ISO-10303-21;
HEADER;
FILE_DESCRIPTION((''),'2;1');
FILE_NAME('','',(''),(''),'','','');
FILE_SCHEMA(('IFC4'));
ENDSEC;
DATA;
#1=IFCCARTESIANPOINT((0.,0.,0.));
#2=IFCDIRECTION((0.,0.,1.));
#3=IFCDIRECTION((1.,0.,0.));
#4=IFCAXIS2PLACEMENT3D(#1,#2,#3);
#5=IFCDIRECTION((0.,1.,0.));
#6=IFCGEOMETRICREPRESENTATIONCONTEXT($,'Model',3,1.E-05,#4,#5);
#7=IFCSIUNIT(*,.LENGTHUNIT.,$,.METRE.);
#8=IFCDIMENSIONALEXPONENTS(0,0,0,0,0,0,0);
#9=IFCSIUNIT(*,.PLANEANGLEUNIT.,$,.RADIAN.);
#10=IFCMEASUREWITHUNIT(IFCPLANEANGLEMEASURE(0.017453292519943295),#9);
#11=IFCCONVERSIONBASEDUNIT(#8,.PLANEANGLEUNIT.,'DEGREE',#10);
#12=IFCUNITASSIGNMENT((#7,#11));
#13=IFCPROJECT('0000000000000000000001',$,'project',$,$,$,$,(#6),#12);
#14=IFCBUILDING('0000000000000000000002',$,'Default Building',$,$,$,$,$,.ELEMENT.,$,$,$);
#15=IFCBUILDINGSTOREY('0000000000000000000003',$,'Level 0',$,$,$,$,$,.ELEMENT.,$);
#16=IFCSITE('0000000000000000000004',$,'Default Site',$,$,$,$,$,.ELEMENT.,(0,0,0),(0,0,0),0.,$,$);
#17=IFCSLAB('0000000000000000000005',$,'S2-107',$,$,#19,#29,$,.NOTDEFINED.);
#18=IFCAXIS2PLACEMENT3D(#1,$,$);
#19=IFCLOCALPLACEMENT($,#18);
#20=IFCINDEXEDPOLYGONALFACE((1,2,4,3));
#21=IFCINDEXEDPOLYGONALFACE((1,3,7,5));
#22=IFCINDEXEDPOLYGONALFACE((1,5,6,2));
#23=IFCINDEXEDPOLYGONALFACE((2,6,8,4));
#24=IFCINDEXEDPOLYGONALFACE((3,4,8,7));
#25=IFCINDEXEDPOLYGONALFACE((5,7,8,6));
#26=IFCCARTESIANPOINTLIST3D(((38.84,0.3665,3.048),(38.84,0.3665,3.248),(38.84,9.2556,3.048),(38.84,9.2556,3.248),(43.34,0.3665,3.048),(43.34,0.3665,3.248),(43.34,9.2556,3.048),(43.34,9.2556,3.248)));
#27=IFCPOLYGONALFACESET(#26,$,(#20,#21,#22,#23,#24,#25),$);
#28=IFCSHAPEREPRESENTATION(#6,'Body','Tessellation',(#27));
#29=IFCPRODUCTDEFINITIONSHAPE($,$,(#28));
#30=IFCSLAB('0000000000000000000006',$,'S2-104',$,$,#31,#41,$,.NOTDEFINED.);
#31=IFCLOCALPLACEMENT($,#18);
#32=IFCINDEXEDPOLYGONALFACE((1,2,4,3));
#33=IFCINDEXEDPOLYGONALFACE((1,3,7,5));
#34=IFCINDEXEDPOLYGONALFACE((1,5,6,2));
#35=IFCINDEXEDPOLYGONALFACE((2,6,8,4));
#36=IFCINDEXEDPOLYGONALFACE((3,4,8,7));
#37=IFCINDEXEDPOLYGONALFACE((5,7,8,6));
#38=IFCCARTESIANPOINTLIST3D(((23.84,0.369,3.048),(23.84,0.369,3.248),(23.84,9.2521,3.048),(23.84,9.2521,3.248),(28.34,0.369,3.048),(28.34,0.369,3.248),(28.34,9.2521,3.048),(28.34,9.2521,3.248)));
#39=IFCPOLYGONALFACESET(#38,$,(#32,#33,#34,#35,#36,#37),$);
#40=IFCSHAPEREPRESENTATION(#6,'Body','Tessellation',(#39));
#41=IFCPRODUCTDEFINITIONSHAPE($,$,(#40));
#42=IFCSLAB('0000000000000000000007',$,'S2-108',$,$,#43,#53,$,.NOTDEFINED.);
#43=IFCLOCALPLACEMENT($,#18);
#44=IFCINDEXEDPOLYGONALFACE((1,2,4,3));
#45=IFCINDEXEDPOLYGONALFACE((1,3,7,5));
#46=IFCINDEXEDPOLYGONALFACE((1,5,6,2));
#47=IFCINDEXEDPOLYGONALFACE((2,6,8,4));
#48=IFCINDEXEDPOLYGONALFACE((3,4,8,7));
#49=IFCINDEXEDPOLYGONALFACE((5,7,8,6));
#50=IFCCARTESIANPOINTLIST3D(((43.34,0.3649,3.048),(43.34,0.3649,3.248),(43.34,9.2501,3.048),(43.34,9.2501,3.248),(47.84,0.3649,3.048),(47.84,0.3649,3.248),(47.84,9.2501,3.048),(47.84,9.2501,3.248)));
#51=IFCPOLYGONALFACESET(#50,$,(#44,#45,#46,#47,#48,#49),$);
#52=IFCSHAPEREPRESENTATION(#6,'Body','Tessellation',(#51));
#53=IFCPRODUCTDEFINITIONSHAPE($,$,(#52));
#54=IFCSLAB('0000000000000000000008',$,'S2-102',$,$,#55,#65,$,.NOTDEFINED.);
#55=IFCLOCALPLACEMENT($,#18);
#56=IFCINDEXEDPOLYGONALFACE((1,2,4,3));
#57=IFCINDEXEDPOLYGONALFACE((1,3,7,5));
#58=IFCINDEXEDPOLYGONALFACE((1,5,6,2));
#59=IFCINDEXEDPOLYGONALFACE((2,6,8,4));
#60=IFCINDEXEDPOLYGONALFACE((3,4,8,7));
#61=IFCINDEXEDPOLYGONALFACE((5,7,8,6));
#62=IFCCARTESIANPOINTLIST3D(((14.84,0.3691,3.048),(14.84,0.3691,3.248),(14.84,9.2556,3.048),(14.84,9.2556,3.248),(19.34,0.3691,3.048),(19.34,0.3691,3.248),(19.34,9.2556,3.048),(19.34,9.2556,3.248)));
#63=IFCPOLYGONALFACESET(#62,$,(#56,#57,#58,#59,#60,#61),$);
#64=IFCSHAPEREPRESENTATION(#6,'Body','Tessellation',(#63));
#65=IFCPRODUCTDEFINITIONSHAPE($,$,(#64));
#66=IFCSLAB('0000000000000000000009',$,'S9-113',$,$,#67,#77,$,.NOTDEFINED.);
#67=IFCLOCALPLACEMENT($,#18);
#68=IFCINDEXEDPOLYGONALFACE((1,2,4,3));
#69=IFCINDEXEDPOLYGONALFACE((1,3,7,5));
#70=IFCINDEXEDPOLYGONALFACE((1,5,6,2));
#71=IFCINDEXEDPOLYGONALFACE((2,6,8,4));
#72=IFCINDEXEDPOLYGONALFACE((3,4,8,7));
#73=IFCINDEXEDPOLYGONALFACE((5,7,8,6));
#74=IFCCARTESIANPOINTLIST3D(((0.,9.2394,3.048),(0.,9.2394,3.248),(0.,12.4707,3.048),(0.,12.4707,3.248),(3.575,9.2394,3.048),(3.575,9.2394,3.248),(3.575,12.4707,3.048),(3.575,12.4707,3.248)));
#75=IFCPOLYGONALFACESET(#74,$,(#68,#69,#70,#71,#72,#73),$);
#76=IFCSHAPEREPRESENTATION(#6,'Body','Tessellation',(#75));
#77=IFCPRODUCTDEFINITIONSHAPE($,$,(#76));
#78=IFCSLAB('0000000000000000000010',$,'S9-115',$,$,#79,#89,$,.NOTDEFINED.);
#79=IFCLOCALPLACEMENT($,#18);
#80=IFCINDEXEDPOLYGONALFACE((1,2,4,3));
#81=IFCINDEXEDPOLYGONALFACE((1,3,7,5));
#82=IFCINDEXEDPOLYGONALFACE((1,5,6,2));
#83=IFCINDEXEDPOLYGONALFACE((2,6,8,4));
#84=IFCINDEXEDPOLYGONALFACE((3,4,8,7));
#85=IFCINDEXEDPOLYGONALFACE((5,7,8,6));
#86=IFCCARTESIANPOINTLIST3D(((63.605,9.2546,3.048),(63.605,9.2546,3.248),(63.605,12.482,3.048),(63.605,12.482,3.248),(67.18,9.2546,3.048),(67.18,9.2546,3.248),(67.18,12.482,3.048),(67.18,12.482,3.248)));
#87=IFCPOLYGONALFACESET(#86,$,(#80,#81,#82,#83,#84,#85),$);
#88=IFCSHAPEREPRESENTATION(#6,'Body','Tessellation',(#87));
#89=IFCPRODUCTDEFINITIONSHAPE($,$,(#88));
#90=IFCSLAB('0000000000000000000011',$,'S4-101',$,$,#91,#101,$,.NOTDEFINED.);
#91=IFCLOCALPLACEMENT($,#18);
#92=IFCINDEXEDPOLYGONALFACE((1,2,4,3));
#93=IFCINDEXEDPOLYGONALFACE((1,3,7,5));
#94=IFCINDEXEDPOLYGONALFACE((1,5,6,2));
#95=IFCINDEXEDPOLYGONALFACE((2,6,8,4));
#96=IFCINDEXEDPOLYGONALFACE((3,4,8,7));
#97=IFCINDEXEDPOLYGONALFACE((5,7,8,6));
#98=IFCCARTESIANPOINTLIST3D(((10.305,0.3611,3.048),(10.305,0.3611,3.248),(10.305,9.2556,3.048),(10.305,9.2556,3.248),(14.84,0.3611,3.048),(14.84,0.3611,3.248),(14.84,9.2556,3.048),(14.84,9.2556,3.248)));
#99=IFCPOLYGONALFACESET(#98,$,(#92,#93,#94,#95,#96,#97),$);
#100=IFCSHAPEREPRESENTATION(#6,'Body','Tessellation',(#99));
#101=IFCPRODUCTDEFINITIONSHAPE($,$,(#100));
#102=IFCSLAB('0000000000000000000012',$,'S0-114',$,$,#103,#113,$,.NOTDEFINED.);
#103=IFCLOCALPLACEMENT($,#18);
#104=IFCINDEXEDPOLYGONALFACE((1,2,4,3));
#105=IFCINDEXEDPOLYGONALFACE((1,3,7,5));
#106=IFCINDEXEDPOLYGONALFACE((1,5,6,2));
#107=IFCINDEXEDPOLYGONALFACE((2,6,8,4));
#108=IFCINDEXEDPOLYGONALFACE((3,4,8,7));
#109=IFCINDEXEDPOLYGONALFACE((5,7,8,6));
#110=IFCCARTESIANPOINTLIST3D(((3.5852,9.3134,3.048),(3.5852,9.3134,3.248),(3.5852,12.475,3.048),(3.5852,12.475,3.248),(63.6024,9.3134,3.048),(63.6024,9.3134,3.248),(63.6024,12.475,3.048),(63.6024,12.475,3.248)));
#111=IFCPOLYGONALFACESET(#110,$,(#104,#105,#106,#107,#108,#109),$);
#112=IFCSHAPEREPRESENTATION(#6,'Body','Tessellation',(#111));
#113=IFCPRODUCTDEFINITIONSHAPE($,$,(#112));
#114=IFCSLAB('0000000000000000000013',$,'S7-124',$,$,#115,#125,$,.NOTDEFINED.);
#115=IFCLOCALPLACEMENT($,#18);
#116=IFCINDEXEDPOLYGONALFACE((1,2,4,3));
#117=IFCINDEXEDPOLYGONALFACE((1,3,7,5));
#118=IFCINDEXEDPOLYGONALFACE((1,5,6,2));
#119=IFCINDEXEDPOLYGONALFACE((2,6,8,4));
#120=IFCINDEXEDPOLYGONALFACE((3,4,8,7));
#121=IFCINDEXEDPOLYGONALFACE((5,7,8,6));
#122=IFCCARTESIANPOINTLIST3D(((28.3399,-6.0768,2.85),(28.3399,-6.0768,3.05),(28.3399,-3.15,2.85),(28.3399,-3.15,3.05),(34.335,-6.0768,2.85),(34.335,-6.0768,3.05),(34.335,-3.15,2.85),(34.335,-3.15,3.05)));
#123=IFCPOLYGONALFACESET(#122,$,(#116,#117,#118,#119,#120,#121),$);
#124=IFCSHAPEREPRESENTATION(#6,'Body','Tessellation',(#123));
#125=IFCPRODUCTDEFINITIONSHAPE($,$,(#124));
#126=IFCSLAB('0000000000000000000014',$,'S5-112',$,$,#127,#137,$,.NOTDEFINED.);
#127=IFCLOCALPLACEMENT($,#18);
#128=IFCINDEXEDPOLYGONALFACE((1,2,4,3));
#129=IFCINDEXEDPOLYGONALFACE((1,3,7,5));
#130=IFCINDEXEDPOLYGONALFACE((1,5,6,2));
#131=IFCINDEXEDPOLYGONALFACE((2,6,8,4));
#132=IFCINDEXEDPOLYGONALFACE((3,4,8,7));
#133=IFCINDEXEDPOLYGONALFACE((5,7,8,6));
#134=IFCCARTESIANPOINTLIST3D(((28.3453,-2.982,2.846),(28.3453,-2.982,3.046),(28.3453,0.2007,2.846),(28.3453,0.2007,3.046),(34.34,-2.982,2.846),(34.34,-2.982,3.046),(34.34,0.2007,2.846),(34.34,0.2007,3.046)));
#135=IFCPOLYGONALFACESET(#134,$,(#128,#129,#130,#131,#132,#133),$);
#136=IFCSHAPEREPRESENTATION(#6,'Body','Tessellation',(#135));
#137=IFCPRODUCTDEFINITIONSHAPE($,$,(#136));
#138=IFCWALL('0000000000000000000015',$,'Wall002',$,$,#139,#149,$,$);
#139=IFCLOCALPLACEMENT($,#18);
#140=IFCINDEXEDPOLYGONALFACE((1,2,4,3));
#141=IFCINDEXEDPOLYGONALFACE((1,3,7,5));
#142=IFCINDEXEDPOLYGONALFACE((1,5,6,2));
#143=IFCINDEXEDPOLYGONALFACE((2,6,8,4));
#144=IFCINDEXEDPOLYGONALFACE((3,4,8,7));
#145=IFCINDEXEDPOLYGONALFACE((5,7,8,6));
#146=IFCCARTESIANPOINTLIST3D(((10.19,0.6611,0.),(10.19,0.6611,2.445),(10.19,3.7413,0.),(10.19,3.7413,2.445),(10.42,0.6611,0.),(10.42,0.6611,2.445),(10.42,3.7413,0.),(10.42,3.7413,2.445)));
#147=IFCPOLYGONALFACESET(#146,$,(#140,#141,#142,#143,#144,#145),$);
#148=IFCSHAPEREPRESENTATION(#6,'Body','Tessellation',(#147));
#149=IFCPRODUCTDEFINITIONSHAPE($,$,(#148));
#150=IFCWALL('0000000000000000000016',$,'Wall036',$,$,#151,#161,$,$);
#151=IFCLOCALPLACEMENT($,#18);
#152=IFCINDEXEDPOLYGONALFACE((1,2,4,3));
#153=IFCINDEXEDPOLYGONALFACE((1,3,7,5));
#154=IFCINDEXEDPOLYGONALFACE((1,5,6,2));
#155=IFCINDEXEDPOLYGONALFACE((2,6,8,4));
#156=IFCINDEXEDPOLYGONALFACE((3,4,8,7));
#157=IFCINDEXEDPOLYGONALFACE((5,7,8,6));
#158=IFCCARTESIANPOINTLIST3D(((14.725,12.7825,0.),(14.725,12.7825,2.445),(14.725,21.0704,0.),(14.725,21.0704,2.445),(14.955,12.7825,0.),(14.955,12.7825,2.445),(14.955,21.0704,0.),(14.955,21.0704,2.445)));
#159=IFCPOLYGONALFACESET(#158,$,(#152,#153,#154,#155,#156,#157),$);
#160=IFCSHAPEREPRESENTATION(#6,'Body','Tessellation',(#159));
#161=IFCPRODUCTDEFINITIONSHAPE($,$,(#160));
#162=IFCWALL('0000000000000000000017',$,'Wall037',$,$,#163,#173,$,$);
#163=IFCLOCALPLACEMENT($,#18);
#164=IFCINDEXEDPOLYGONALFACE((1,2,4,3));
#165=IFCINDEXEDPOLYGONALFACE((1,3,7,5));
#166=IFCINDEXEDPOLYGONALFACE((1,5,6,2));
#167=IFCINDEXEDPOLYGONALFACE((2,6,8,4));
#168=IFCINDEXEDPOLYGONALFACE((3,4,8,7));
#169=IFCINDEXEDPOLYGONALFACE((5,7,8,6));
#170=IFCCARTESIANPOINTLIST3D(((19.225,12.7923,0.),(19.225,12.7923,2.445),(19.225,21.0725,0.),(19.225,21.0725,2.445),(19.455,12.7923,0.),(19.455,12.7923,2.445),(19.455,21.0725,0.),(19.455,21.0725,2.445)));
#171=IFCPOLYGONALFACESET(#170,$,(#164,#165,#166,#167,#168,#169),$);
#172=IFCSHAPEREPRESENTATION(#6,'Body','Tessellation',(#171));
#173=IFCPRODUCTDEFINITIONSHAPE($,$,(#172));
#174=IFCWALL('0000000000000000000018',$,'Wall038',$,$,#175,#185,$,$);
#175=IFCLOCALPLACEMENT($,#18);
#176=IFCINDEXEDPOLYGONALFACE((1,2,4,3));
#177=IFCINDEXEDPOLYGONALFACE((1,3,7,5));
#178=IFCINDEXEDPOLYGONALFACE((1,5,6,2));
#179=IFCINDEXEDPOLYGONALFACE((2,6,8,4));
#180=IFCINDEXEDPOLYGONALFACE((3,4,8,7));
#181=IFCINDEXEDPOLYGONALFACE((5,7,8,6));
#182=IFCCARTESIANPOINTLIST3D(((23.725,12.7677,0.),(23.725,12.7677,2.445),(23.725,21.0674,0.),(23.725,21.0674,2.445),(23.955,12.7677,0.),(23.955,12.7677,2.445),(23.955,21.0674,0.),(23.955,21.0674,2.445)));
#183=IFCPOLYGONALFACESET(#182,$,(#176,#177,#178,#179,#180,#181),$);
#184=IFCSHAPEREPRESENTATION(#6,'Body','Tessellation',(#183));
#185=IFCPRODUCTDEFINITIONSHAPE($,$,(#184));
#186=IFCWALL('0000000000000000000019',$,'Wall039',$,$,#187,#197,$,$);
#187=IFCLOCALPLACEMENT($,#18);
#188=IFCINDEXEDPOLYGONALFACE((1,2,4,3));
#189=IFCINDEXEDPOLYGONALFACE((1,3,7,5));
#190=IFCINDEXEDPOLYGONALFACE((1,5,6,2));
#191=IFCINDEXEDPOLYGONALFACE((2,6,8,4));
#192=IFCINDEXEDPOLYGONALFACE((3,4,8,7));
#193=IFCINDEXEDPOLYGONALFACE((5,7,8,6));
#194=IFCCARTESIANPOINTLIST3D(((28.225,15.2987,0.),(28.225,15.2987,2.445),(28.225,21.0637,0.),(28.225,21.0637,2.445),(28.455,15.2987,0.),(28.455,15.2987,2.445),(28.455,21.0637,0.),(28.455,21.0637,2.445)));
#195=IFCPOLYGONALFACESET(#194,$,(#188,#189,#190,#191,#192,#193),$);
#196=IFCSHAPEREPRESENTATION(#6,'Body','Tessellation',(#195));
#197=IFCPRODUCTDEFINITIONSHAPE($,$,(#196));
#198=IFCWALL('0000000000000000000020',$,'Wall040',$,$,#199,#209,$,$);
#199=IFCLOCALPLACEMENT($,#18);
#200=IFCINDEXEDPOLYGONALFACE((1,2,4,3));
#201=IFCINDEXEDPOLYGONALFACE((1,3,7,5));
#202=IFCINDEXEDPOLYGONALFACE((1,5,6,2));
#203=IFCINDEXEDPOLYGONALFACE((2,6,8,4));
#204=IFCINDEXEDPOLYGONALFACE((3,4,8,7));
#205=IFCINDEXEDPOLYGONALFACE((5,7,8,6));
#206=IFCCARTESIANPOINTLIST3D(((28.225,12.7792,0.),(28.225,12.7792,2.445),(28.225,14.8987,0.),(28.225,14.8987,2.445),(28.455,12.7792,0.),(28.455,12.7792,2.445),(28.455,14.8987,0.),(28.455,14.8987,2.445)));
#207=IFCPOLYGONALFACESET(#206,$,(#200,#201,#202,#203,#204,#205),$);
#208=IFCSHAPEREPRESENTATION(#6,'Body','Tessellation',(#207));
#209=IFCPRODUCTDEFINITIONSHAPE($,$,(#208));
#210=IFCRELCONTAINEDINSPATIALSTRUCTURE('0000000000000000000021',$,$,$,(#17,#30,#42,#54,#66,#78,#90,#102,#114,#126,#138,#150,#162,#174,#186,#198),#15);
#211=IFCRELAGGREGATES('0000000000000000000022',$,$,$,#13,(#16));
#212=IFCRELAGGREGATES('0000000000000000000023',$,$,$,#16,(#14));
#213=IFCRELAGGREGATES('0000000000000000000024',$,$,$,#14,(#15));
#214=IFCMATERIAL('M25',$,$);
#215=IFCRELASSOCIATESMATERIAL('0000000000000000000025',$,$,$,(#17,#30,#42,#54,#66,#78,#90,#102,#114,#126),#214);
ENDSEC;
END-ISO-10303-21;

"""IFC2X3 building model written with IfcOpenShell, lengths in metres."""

from ifc_helpers import new_model, entity, si_unit, converted_unit, direction, frame, frame_2d, origin_with_axes, place, context, project, spatial, rectangle, extrude, material, element, save


model = new_model("IFC2X3")

# Units and contexts
model_context = context("Model", 3, precision=1e-05, world=origin_with_axes(), true_north=direction((0.0, 1.0, 0.0)))
ifc_project = project(units=[si_unit("LENGTHUNIT", "METRE"), converted_unit("PLANEANGLEUNIT", "DEGREE", entity("IfcPlaneAngleMeasure", 0.017453292519943295), si_unit("PLANEANGLEUNIT", "RADIAN"), dimensions=[0, 0, 0, 0, 0, 0, 0])], contexts=[model_context])

# Site, building, storey
site = spatial("IfcSite", under=ifc_project, Name="Default Site", CompositionType="ELEMENT", RefLatitude=(0, 0, 0), RefLongitude=(0, 0, 0), RefElevation=0.0)
building = spatial("IfcBuilding", under=site, Name="Default Building", CompositionType="ELEMENT")
storey = spatial("IfcBuildingStorey", under=building, Name="Level 0", CompositionType="ELEMENT")

# Slabs
ifc_material = material(Name="M25")
placement = place(None, origin_with_axes())
element("IfcSlab", 1, at=placement, inside=storey, material=ifc_material, Name="S2-107", PredefinedType="NOTDEFINED", context=model_context, shape_type="SweptSolid", body=[
    extrude(rectangle(XDim=4.5, YDim=8.8891, at=frame_2d((0.0, 0.0), x_axis=(1.0, 0.0, 0.0))), frame((41.09, 4.811, 3.048), z_axis=(0.0, 0.0, 1.0), x_axis=(1.0, 0.0, 0.0)), (0.0, 0.0, 1.0), 0.2),
])
element("IfcSlab", 2, at=placement, inside=storey, material=ifc_material, Name="S2-104", PredefinedType="NOTDEFINED", context=model_context, shape_type="SweptSolid", body=[
    extrude(rectangle(XDim=4.5, YDim=8.8831, at=frame_2d((0.0, 0.0), x_axis=(1.0, 0.0, 0.0))), frame((26.09, 4.8106, 3.048), z_axis=(0.0, 0.0, 1.0), x_axis=(1.0, 0.0, 0.0)), (0.0, 0.0, 1.0), 0.2),
])
element("IfcSlab", 3, at=placement, inside=storey, material=ifc_material, Name="S2-108", PredefinedType="NOTDEFINED", context=model_context, shape_type="SweptSolid", body=[
    extrude(rectangle(XDim=4.5, YDim=8.8852, at=frame_2d((0.0, 0.0), x_axis=(1.0, 0.0, 0.0))), frame((45.59, 4.8075, 3.048), z_axis=(0.0, 0.0, 1.0), x_axis=(1.0, 0.0, 0.0)), (0.0, 0.0, 1.0), 0.2),
])
element("IfcSlab", 4, at=placement, inside=storey, material=ifc_material, Name="S2-102", PredefinedType="NOTDEFINED", context=model_context, shape_type="SweptSolid", body=[
    extrude(rectangle(XDim=4.5, YDim=8.8865, at=frame_2d((0.0, 0.0), x_axis=(1.0, 0.0, 0.0))), frame((17.09, 4.8123, 3.048), z_axis=(0.0, 0.0, 1.0), x_axis=(1.0, 0.0, 0.0)), (0.0, 0.0, 1.0), 0.2),
])
element("IfcSlab", 5, at=placement, inside=storey, material=ifc_material, Name="S9-113", PredefinedType="NOTDEFINED", context=model_context, shape_type="SweptSolid", body=[
    extrude(rectangle(XDim=3.575, YDim=3.2313, at=frame_2d((0.0, 0.0), x_axis=(1.0, 0.0, 0.0))), frame((1.7875, 10.8551, 3.048), z_axis=(0.0, 0.0, 1.0), x_axis=(1.0, 0.0, 0.0)), (0.0, 0.0, 1.0), 0.2),
])
element("IfcSlab", 6, at=placement, inside=storey, material=ifc_material, Name="S9-115", PredefinedType="NOTDEFINED", context=model_context, shape_type="SweptSolid", body=[
    extrude(rectangle(XDim=3.575, YDim=3.2274, at=frame_2d((0.0, 0.0), x_axis=(1.0, 0.0, 0.0))), frame((65.3925, 10.8683, 3.048), z_axis=(0.0, 0.0, 1.0), x_axis=(1.0, 0.0, 0.0)), (0.0, 0.0, 1.0), 0.2),
])
element("IfcSlab", 7, at=placement, inside=storey, material=ifc_material, Name="S4-101", PredefinedType="NOTDEFINED", context=model_context, shape_type="SweptSolid", body=[
    extrude(rectangle(XDim=4.535, YDim=8.8945, at=frame_2d((0.0, 0.0), x_axis=(1.0, 0.0, 0.0))), frame((12.5725, 4.8083, 3.048), z_axis=(0.0, 0.0, 1.0), x_axis=(1.0, 0.0, 0.0)), (0.0, 0.0, 1.0), 0.2),
])
element("IfcSlab", 8, at=placement, inside=storey, material=ifc_material, Name="S0-114", PredefinedType="NOTDEFINED", context=model_context, shape_type="SweptSolid", body=[
    extrude(rectangle(XDim=60.0172, YDim=3.1616, at=frame_2d((0.0, 0.0), x_axis=(1.0, 0.0, 0.0))), frame((33.5938, 10.8942, 3.048), z_axis=(0.0, 0.0, 1.0), x_axis=(1.0, 0.0, 0.0)), (0.0, 0.0, 1.0), 0.2),
])
element("IfcSlab", 9, at=placement, inside=storey, material=ifc_material, Name="S7-124", PredefinedType="NOTDEFINED", context=model_context, shape_type="SweptSolid", body=[
    extrude(rectangle(XDim=5.9951, YDim=2.9268, at=frame_2d((0.0, 0.0), x_axis=(1.0, 0.0, 0.0))), frame((31.3375, -4.6134, 2.85), z_axis=(0.0, 0.0, 1.0), x_axis=(1.0, 0.0, 0.0)), (0.0, 0.0, 1.0), 0.2),
])
element("IfcSlab", 10, at=placement, inside=storey, material=ifc_material, Name="S5-112", PredefinedType="NOTDEFINED", context=model_context, shape_type="SweptSolid", body=[
    extrude(rectangle(XDim=5.9947, YDim=3.1827, at=frame_2d((0.0, 0.0), x_axis=(1.0, 0.0, 0.0))), frame((31.3427, -1.3907, 2.846), z_axis=(0.0, 0.0, 1.0), x_axis=(1.0, 0.0, 0.0)), (0.0, 0.0, 1.0), 0.2),
])

# Walls
element("IfcWall", 11, at=placement, inside=storey, Name="Wall002", context=model_context, shape_type="SweptSolid", body=[
    extrude(rectangle(XDim=3.0802, YDim=0.23, at=frame_2d((0.0, 0.0), x_axis=(0.0, -1.0, 0.0))), frame((10.305, 2.2012, 0.0), z_axis=(0.0, 0.0, 1.0), x_axis=(1.0, 0.0, 0.0)), (0.0, 0.0, 1.0), 2.445),
])
element("IfcWall", 12, at=placement, inside=storey, Name="Wall036", context=model_context, shape_type="SweptSolid", body=[
    extrude(rectangle(XDim=8.2879, YDim=0.23, at=frame_2d((0.0, 0.0), x_axis=(0.0, -1.0, 0.0))), frame((14.84, 16.9264, 0.0), z_axis=(0.0, 0.0, 1.0), x_axis=(1.0, 0.0, 0.0)), (0.0, 0.0, 1.0), 2.445),
])
element("IfcWall", 13, at=placement, inside=storey, Name="Wall037", context=model_context, shape_type="SweptSolid", body=[
    extrude(rectangle(XDim=8.2802, YDim=0.23, at=frame_2d((0.0, 0.0), x_axis=(0.0, -1.0, 0.0))), frame((19.34, 16.9324, 0.0), z_axis=(0.0, 0.0, 1.0), x_axis=(1.0, 0.0, 0.0)), (0.0, 0.0, 1.0), 2.445),
])
element("IfcWall", 14, at=placement, inside=storey, Name="Wall038", context=model_context, shape_type="SweptSolid", body=[
    extrude(rectangle(XDim=8.2997, YDim=0.23, at=frame_2d((0.0, 0.0), x_axis=(0.0, -1.0, 0.0))), frame((23.84, 16.9175, 0.0), z_axis=(0.0, 0.0, 1.0), x_axis=(1.0, 0.0, 0.0)), (0.0, 0.0, 1.0), 2.445),
])
element("IfcWall", 15, at=placement, inside=storey, Name="Wall039", context=model_context, shape_type="SweptSolid", body=[
    extrude(rectangle(XDim=5.765, YDim=0.23, at=frame_2d((0.0, 0.0), x_axis=(0.0, -1.0, 0.0))), frame((28.34, 18.1812, 0.0), z_axis=(0.0, 0.0, 1.0), x_axis=(1.0, 0.0, 0.0)), (0.0, 0.0, 1.0), 2.445),
])
element("IfcWall", 16, at=placement, inside=storey, Name="Wall040", context=model_context, shape_type="SweptSolid", body=[
    extrude(rectangle(XDim=2.1195, YDim=0.23, at=frame_2d((0.0, 0.0), x_axis=(0.0, 1.0, 0.0))), frame((28.34, 13.8389, 0.0), z_axis=(0.0, 0.0, 1.0), x_axis=(1.0, 0.0, 0.0)), (0.0, 0.0, 1.0), 2.445),
])

save(model, "model.ifc")
